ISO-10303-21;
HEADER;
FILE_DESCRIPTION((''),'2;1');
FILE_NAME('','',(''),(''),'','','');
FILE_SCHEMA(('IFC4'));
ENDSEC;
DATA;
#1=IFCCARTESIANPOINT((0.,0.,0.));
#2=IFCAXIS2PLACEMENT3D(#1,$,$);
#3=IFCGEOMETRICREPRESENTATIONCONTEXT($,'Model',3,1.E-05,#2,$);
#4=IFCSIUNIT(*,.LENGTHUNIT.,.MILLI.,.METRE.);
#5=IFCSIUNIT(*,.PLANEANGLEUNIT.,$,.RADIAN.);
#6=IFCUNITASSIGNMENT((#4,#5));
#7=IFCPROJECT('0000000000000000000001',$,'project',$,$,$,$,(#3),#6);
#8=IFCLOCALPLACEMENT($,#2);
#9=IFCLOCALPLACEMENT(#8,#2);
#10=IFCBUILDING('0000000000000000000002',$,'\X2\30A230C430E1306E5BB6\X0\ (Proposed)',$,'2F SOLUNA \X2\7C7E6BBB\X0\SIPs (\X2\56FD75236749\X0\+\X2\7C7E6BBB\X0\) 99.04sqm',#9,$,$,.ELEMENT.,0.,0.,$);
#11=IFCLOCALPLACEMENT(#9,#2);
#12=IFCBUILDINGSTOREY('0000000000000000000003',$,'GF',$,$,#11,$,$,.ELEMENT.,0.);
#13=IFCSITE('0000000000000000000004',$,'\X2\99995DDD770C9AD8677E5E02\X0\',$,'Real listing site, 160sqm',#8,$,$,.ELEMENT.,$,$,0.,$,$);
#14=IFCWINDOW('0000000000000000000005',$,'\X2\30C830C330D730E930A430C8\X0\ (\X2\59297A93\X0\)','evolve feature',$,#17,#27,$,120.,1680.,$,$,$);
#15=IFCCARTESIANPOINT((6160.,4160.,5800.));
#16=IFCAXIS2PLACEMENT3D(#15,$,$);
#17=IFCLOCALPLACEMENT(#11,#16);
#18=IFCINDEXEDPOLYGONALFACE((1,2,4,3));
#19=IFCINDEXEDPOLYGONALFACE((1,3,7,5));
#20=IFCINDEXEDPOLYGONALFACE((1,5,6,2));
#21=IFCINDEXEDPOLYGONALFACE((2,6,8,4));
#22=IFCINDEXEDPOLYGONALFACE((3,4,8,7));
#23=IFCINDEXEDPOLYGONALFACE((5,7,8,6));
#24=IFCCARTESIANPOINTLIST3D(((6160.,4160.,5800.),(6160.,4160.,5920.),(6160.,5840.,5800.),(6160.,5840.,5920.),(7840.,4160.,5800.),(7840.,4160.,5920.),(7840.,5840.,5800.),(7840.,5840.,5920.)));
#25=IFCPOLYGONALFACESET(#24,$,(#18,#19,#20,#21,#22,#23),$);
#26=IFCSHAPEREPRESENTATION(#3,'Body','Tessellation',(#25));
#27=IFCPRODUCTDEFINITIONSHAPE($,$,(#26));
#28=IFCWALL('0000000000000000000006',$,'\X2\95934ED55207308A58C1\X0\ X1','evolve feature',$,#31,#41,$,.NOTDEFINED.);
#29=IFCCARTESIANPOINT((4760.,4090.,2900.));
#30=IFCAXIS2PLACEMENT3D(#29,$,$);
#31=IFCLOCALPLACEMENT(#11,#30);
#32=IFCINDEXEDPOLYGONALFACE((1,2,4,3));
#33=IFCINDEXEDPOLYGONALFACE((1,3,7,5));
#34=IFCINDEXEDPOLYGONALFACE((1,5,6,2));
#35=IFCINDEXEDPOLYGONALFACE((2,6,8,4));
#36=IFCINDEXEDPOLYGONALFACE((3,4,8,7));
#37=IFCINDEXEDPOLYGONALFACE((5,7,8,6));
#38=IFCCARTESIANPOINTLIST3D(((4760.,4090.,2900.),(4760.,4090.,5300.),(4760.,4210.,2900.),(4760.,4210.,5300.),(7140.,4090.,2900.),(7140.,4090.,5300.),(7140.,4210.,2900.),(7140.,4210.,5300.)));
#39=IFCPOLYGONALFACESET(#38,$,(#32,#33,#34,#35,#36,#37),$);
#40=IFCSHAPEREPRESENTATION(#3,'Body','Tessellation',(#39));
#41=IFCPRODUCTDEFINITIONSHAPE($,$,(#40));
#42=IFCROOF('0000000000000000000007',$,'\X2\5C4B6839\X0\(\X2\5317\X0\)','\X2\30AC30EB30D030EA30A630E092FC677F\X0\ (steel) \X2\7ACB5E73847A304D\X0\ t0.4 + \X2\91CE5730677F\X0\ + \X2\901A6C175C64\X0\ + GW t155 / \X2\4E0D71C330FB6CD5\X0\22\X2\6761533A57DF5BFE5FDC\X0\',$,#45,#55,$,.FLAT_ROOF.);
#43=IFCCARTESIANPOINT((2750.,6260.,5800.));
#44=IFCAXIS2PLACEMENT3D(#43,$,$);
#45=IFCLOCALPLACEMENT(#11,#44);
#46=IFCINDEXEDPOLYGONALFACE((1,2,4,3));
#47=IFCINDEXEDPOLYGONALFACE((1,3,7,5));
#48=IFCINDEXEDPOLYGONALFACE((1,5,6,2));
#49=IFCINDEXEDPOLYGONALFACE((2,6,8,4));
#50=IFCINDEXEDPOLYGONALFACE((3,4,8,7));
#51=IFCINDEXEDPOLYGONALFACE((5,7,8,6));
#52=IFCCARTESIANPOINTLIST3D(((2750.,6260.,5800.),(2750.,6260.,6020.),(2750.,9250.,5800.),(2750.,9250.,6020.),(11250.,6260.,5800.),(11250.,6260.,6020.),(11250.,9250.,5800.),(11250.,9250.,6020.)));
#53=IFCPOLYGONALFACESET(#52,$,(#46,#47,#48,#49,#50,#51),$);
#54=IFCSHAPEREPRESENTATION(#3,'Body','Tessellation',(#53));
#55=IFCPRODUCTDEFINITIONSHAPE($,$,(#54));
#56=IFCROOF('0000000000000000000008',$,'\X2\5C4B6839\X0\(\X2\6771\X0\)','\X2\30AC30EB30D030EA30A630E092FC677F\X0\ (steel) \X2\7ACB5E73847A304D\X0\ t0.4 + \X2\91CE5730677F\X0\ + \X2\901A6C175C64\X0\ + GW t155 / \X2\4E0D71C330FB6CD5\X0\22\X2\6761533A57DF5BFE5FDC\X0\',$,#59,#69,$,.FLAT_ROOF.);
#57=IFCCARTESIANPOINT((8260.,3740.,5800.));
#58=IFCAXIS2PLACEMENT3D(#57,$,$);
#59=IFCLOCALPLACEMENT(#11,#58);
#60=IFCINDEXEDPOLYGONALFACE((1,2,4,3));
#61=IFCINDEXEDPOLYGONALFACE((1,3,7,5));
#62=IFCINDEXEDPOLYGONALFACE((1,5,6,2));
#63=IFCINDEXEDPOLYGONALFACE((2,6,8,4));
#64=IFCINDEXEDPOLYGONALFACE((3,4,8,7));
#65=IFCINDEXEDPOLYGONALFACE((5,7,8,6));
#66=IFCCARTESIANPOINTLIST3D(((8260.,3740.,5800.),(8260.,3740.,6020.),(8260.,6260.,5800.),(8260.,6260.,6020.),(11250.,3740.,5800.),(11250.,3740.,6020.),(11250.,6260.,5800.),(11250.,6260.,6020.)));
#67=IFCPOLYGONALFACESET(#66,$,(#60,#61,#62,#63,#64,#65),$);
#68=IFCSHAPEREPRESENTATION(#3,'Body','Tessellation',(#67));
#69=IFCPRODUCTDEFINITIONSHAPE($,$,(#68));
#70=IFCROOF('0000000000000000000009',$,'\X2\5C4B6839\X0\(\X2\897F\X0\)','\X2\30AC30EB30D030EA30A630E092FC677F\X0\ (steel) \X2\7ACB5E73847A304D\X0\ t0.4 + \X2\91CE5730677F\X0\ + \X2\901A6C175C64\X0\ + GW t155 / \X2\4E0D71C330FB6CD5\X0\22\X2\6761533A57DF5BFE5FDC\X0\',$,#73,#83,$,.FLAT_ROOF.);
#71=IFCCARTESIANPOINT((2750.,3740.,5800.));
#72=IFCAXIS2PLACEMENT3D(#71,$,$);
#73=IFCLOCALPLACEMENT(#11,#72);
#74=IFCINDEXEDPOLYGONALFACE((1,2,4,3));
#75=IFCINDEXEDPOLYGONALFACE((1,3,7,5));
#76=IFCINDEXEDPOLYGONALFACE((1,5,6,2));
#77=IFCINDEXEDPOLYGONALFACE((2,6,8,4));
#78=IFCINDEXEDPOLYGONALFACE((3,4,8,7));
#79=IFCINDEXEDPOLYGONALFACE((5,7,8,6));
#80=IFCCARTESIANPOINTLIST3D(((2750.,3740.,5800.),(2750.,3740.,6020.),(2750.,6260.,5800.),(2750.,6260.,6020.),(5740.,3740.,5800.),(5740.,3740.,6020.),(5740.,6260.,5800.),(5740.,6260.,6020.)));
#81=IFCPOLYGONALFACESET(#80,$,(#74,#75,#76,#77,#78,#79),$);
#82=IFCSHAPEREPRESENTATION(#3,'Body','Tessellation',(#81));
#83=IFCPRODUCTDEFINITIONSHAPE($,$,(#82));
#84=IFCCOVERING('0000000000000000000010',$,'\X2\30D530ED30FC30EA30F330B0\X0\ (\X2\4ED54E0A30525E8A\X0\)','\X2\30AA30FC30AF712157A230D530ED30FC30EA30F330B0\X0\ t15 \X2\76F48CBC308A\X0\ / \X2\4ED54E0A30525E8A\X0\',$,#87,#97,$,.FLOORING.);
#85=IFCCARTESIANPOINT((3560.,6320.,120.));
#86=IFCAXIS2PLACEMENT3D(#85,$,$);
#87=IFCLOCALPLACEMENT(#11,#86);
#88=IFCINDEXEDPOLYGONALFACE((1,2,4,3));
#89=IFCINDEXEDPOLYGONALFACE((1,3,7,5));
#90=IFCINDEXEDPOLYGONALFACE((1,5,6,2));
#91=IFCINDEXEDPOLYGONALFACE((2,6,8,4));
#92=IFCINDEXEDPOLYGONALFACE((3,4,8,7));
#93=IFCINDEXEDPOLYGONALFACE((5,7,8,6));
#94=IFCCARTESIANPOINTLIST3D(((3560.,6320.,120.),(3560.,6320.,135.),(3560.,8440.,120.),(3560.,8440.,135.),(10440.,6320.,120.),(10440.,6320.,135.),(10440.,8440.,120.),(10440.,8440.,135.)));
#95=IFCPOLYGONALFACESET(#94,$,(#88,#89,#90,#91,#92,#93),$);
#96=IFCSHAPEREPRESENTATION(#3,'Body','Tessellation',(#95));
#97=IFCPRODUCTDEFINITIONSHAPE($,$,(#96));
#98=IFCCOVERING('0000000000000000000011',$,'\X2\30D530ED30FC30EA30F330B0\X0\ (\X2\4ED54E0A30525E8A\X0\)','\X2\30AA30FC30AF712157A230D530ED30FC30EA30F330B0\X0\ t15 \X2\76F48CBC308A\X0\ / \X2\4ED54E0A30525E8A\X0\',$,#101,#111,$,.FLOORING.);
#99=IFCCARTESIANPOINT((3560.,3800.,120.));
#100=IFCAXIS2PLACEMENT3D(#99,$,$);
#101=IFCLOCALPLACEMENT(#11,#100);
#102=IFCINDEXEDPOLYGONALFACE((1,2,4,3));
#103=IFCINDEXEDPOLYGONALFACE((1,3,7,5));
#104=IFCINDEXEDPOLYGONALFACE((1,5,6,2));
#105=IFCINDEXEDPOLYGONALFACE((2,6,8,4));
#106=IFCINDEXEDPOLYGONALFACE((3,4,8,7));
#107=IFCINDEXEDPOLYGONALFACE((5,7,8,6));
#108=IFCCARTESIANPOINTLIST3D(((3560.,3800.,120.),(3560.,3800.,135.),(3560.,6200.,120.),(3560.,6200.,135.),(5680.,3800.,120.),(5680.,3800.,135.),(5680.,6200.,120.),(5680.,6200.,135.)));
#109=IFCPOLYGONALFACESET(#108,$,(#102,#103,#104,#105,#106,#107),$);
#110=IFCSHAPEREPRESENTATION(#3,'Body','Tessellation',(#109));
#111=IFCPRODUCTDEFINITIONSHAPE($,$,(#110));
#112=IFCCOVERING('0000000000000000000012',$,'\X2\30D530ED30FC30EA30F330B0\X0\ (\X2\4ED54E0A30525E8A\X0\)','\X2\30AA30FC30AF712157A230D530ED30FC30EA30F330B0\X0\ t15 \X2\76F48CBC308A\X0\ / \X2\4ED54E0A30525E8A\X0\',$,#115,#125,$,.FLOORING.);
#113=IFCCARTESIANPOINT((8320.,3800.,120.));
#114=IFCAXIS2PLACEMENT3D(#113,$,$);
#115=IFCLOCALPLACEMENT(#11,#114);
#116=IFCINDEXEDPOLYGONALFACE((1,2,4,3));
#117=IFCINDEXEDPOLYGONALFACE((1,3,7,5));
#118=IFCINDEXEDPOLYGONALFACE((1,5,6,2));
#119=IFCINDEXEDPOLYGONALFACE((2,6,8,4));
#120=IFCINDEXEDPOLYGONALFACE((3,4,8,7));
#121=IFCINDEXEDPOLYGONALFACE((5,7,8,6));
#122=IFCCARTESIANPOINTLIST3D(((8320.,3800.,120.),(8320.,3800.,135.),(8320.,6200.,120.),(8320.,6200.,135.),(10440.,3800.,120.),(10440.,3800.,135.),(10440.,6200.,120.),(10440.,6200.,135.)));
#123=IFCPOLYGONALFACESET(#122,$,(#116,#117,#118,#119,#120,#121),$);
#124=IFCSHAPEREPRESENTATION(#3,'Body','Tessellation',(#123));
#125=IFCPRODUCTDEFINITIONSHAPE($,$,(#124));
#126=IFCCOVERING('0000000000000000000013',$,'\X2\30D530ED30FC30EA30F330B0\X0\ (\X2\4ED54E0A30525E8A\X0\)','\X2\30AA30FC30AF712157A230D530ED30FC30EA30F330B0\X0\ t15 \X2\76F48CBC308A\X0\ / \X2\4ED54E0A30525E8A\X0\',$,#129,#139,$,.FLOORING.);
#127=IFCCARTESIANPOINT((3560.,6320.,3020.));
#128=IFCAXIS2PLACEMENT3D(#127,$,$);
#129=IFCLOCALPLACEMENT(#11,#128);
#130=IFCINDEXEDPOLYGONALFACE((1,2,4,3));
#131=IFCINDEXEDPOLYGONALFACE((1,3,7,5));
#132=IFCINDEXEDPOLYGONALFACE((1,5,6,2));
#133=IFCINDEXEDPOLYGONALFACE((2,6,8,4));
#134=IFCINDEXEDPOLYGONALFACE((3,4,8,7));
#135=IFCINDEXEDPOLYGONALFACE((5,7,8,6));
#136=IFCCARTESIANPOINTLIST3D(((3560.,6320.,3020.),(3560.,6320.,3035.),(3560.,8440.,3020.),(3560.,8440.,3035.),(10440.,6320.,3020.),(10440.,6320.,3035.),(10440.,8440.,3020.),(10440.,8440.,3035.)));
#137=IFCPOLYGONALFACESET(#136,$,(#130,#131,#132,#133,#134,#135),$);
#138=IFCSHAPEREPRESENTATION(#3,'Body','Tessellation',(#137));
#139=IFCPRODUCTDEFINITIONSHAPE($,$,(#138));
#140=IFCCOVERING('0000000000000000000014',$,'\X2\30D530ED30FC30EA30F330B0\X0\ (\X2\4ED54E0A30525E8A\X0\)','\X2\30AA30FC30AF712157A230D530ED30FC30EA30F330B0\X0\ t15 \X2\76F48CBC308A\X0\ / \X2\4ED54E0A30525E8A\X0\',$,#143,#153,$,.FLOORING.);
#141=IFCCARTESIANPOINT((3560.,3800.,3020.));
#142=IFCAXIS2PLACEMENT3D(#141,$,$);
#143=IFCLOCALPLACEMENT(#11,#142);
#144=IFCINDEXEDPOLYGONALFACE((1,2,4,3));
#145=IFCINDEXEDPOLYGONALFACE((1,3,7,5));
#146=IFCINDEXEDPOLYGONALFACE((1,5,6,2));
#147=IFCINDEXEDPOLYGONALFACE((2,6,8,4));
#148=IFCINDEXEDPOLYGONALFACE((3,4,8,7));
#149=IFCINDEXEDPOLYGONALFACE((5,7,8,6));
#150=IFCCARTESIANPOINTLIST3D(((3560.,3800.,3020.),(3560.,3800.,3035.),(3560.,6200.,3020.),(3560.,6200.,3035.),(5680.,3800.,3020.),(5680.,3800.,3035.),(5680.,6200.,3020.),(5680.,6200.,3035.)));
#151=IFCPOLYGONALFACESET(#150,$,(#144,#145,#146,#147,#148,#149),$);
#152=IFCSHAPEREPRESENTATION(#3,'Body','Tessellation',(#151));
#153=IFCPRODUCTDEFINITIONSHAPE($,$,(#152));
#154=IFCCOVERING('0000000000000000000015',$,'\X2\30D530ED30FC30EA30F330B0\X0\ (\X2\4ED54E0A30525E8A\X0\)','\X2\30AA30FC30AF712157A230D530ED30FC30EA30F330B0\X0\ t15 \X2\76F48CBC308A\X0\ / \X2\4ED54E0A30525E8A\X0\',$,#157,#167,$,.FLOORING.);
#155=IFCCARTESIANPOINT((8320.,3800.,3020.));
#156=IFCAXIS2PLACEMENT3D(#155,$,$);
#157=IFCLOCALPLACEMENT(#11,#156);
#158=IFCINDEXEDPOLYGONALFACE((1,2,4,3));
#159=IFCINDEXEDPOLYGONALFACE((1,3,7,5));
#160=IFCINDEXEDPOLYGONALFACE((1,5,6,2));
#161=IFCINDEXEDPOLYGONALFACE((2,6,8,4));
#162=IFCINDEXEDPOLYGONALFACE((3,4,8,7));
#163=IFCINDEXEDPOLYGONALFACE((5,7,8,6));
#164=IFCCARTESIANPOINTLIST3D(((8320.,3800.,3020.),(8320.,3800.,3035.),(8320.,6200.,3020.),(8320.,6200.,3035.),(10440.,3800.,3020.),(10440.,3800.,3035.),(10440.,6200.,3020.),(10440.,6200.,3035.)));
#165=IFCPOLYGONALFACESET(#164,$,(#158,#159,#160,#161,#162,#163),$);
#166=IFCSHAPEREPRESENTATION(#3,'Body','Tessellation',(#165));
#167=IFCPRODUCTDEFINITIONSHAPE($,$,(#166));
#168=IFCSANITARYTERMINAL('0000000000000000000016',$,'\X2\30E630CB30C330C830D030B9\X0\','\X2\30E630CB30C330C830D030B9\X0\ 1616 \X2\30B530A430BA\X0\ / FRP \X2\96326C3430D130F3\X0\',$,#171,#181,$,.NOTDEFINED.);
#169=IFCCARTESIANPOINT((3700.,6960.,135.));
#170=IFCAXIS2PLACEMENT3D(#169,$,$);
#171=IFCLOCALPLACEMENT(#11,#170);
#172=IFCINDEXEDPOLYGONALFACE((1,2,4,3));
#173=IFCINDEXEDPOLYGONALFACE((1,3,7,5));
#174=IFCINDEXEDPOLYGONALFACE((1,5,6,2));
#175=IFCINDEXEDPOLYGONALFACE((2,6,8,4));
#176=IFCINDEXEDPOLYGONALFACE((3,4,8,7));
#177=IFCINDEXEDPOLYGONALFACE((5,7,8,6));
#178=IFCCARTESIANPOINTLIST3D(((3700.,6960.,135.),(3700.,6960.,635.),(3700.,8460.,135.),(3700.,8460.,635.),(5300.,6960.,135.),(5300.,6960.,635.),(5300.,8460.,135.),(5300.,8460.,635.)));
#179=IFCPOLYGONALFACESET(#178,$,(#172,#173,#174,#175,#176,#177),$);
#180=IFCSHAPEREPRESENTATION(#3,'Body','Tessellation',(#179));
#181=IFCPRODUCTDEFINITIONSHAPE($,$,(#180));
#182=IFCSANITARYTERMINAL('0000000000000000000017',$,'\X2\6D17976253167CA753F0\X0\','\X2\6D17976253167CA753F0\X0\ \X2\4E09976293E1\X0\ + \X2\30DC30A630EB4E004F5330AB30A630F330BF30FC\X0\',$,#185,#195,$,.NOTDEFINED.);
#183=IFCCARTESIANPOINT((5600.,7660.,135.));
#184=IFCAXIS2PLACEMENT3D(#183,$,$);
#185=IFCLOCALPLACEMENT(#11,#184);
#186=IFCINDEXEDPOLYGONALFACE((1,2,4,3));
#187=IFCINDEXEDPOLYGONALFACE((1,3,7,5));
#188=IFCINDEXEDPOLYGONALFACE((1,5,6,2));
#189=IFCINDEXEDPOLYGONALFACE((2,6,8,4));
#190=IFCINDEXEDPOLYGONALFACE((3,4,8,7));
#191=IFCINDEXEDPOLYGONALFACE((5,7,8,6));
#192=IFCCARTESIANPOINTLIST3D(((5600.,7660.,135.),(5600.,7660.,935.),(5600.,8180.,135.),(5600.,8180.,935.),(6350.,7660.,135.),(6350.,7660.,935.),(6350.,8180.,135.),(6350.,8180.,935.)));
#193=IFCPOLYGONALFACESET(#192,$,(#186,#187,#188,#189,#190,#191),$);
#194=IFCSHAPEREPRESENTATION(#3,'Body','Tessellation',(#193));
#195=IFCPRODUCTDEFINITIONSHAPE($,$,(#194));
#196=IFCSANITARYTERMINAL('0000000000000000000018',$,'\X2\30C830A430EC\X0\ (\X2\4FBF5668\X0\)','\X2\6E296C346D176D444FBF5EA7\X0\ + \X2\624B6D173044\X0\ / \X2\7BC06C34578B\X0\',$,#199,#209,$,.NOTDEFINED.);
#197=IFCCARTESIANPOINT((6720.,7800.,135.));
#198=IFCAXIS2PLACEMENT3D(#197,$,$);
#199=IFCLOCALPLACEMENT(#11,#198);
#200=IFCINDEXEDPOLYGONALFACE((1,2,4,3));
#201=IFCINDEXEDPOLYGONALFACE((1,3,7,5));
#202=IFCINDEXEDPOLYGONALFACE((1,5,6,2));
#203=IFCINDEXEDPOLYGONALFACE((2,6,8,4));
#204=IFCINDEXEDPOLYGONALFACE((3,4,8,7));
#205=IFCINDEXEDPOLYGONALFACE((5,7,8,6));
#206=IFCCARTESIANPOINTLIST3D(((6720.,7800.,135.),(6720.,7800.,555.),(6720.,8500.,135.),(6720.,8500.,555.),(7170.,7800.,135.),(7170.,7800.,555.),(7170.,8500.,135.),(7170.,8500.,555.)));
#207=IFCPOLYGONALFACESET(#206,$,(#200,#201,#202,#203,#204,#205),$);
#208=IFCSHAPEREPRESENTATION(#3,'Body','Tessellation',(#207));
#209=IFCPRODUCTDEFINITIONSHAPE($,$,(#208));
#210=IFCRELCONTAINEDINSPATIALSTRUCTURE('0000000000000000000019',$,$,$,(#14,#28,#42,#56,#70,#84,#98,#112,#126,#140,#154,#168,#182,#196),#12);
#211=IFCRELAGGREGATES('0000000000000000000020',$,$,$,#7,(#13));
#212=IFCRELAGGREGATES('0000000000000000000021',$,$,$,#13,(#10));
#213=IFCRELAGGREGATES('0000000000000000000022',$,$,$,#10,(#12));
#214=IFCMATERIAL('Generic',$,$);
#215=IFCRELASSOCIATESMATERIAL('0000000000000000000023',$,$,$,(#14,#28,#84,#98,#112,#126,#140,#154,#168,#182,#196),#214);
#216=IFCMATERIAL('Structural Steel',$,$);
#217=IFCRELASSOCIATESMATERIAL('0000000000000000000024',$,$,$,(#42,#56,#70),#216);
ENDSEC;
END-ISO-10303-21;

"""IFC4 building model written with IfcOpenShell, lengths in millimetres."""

from ifc_helpers import new_model, si_unit, frame, frame_2d, origin, place, context, project, spatial, rectangle, extrude, material, element, save


model = new_model("IFC4")

# Units and contexts
model_context = context("Model", 3, precision=1e-05, world=origin())
ifc_project = project(units=[si_unit("LENGTHUNIT", "METRE", prefix="MILLI"), si_unit("PLANEANGLEUNIT", "RADIAN")], contexts=[model_context])

# Site, building, storey
site_placement = place(None, origin())
site = spatial("IfcSite", under=ifc_project, at=site_placement, Name="香川県高松市", ObjectType="Real listing site, 160sqm", CompositionType="ELEMENT", RefElevation=0.0)
building_placement = place(site_placement, origin())
building = spatial("IfcBuilding", under=site, at=building_placement, Name="アツメの家 (Proposed)", ObjectType="2F SOLUNA 籾殻SIPs (国産杉+籾殻) 99.04sqm", CompositionType="ELEMENT", ElevationOfRefHeight=0.0, ElevationOfTerrain=0.0)
storey_placement = place(building_placement, origin())
storey = spatial("IfcBuildingStorey", under=building, at=storey_placement, Name="GF", CompositionType="ELEMENT", Elevation=0.0)

# Window
ifc_material_1 = material(Name="Generic")
window_1_placement = place(storey_placement, frame((6160.0, 4160.0, 5800.0)))
element("IfcWindow", 1, at=window_1_placement, inside=storey, material=ifc_material_1, Name="トップライト (天窓)", Description="evolve feature", OverallHeight=120.0, OverallWidth=1680.0, context=model_context, shape_type="SweptSolid", body=[
    extrude(rectangle(XDim=1680.0, YDim=1680.0, at=frame_2d((840.0, 840.0))), frame((6160.0, 4160.0, 5800.0)), (0.0, 0.0, 1.0), 120.0),
])

# Wall
wall_1_placement = place(storey_placement, frame((4760.0, 4090.0, 2900.0)))
element("IfcWall", 2, at=wall_1_placement, inside=storey, material=ifc_material_1, Name="間仕切り壁 X1", Description="evolve feature", PredefinedType="NOTDEFINED", context=model_context, shape_type="SweptSolid", body=[
    extrude(rectangle(XDim=2380.0, YDim=120.0, at=frame_2d((1190.0, 60.0))), frame((4760.0, 4090.0, 2900.0)), (0.0, 0.0, 1.0), 2400.0),
])

# Roofs
ifc_material_2 = material(Name="Structural Steel")
roof_1_placement = place(storey_placement, frame((2750.0, 6260.0, 5800.0)))
element("IfcRoof", 3, at=roof_1_placement, inside=storey, material=ifc_material_2, Name="屋根(北)", Description="ガルバリウム鋼板 (steel) 立平葺き t0.4 + 野地板 + 通気層 + GW t155 / 不燃・法22条区域対応", PredefinedType="FLAT_ROOF", context=model_context, shape_type="SweptSolid", body=[
    extrude(rectangle(XDim=8500.0, YDim=2990.0, at=frame_2d((4250.0, 1495.0))), frame((2750.0, 6260.0, 5800.0)), (0.0, 0.0, 1.0), 220.0),
])
roof_2_placement = place(storey_placement, frame((8260.0, 3740.0, 5800.0)))
element("IfcRoof", 4, at=roof_2_placement, inside=storey, material=ifc_material_2, Name="屋根(東)", Description="ガルバリウム鋼板 (steel) 立平葺き t0.4 + 野地板 + 通気層 + GW t155 / 不燃・法22条区域対応", PredefinedType="FLAT_ROOF", context=model_context, shape_type="SweptSolid", body=[
    extrude(rectangle(XDim=2990.0, YDim=2520.0, at=frame_2d((1495.0, 1260.0))), frame((8260.0, 3740.0, 5800.0)), (0.0, 0.0, 1.0), 220.0),
])
roof_3_placement = place(storey_placement, frame((2750.0, 3740.0, 5800.0)))
element("IfcRoof", 5, at=roof_3_placement, inside=storey, material=ifc_material_2, Name="屋根(西)", Description="ガルバリウム鋼板 (steel) 立平葺き t0.4 + 野地板 + 通気層 + GW t155 / 不燃・法22条区域対応", PredefinedType="FLAT_ROOF", context=model_context, shape_type="SweptSolid", body=[
    extrude(rectangle(XDim=2990.0, YDim=2520.0, at=frame_2d((1495.0, 1260.0))), frame((2750.0, 3740.0, 5800.0)), (0.0, 0.0, 1.0), 220.0),
])

# Coverings
covering_1_placement = place(storey_placement, frame((3560.0, 6320.0, 120.0)))
element("IfcCovering", 6, at=covering_1_placement, inside=storey, material=ifc_material_1, Name="フローリング (仕上げ床)", Description="オーク無垢フローリング t15 直貼り / 仕上げ床", PredefinedType="FLOORING", context=model_context, shape_type="SweptSolid", body=[
    extrude(rectangle(XDim=6880.0, YDim=2120.0, at=frame_2d((3440.0, 1060.0))), frame((3560.0, 6320.0, 120.0)), (0.0, 0.0, 1.0), 15.0),
])
covering_2_placement = place(storey_placement, frame((3560.0, 3800.0, 120.0)))
element("IfcCovering", 7, at=covering_2_placement, inside=storey, material=ifc_material_1, Name="フローリング (仕上げ床)", Description="オーク無垢フローリング t15 直貼り / 仕上げ床", PredefinedType="FLOORING", context=model_context, shape_type="SweptSolid", body=[
    extrude(rectangle(XDim=2120.0, YDim=2400.0, at=frame_2d((1060.0, 1200.0))), frame((3560.0, 3800.0, 120.0)), (0.0, 0.0, 1.0), 15.0),
])
covering_3_placement = place(storey_placement, frame((8320.0, 3800.0, 120.0)))
element("IfcCovering", 8, at=covering_3_placement, inside=storey, material=ifc_material_1, Name="フローリング (仕上げ床)", Description="オーク無垢フローリング t15 直貼り / 仕上げ床", PredefinedType="FLOORING", context=model_context, shape_type="SweptSolid", body=[
    extrude(rectangle(XDim=2120.0, YDim=2400.0, at=frame_2d((1060.0, 1200.0))), frame((8320.0, 3800.0, 120.0)), (0.0, 0.0, 1.0), 15.0),
])
covering_4_placement = place(storey_placement, frame((3560.0, 6320.0, 3020.0)))
element("IfcCovering", 9, at=covering_4_placement, inside=storey, material=ifc_material_1, Name="フローリング (仕上げ床)", Description="オーク無垢フローリング t15 直貼り / 仕上げ床", PredefinedType="FLOORING", context=model_context, shape_type="SweptSolid", body=[
    extrude(rectangle(XDim=6880.0, YDim=2120.0, at=frame_2d((3440.0, 1060.0))), frame((3560.0, 6320.0, 3020.0)), (0.0, 0.0, 1.0), 15.0),
])
covering_5_placement = place(storey_placement, frame((3560.0, 3800.0, 3020.0)))
element("IfcCovering", 10, at=covering_5_placement, inside=storey, material=ifc_material_1, Name="フローリング (仕上げ床)", Description="オーク無垢フローリング t15 直貼り / 仕上げ床", PredefinedType="FLOORING", context=model_context, shape_type="SweptSolid", body=[
    extrude(rectangle(XDim=2120.0, YDim=2400.0, at=frame_2d((1060.0, 1200.0))), frame((3560.0, 3800.0, 3020.0)), (0.0, 0.0, 1.0), 15.0),
])
covering_6_placement = place(storey_placement, frame((8320.0, 3800.0, 3020.0)))
element("IfcCovering", 11, at=covering_6_placement, inside=storey, material=ifc_material_1, Name="フローリング (仕上げ床)", Description="オーク無垢フローリング t15 直貼り / 仕上げ床", PredefinedType="FLOORING", context=model_context, shape_type="SweptSolid", body=[
    extrude(rectangle(XDim=2120.0, YDim=2400.0, at=frame_2d((1060.0, 1200.0))), frame((8320.0, 3800.0, 3020.0)), (0.0, 0.0, 1.0), 15.0),
])

# Sanitary terminals
sanitary_terminal_1_placement = place(storey_placement, frame((3700.0, 6960.0, 135.0)))
element("IfcSanitaryTerminal", 12, at=sanitary_terminal_1_placement, inside=storey, material=ifc_material_1, Name="ユニットバス", Description="ユニットバス 1616 サイズ / FRP 防水パン", PredefinedType="NOTDEFINED", context=model_context, shape_type="SweptSolid", body=[
    extrude(rectangle(XDim=1600.0, YDim=1500.0, at=frame_2d((800.0, 750.0))), frame((3700.0, 6960.0, 135.0)), (0.0, 0.0, 1.0), 500.0),
])
sanitary_terminal_2_placement = place(storey_placement, frame((5600.0, 7660.0, 135.0)))
element("IfcSanitaryTerminal", 13, at=sanitary_terminal_2_placement, inside=storey, material=ifc_material_1, Name="洗面化粧台", Description="洗面化粧台 三面鏡 + ボウル一体カウンター", PredefinedType="NOTDEFINED", context=model_context, shape_type="SweptSolid", body=[
    extrude(rectangle(XDim=750.0, YDim=520.0, at=frame_2d((375.0, 260.0))), frame((5600.0, 7660.0, 135.0)), (0.0, 0.0, 1.0), 800.0),
])
sanitary_terminal_3_placement = place(storey_placement, frame((6720.0, 7800.0, 135.0)))
element("IfcSanitaryTerminal", 14, at=sanitary_terminal_3_placement, inside=storey, material=ifc_material_1, Name="トイレ (便器)", Description="温水洗浄便座 + 手洗い / 節水型", PredefinedType="NOTDEFINED", context=model_context, shape_type="SweptSolid", body=[
    extrude(rectangle(XDim=450.0, YDim=700.0, at=frame_2d((225.0, 350.0))), frame((6720.0, 7800.0, 135.0)), (0.0, 0.0, 1.0), 420.0),
])

save(model, "model.ifc")
